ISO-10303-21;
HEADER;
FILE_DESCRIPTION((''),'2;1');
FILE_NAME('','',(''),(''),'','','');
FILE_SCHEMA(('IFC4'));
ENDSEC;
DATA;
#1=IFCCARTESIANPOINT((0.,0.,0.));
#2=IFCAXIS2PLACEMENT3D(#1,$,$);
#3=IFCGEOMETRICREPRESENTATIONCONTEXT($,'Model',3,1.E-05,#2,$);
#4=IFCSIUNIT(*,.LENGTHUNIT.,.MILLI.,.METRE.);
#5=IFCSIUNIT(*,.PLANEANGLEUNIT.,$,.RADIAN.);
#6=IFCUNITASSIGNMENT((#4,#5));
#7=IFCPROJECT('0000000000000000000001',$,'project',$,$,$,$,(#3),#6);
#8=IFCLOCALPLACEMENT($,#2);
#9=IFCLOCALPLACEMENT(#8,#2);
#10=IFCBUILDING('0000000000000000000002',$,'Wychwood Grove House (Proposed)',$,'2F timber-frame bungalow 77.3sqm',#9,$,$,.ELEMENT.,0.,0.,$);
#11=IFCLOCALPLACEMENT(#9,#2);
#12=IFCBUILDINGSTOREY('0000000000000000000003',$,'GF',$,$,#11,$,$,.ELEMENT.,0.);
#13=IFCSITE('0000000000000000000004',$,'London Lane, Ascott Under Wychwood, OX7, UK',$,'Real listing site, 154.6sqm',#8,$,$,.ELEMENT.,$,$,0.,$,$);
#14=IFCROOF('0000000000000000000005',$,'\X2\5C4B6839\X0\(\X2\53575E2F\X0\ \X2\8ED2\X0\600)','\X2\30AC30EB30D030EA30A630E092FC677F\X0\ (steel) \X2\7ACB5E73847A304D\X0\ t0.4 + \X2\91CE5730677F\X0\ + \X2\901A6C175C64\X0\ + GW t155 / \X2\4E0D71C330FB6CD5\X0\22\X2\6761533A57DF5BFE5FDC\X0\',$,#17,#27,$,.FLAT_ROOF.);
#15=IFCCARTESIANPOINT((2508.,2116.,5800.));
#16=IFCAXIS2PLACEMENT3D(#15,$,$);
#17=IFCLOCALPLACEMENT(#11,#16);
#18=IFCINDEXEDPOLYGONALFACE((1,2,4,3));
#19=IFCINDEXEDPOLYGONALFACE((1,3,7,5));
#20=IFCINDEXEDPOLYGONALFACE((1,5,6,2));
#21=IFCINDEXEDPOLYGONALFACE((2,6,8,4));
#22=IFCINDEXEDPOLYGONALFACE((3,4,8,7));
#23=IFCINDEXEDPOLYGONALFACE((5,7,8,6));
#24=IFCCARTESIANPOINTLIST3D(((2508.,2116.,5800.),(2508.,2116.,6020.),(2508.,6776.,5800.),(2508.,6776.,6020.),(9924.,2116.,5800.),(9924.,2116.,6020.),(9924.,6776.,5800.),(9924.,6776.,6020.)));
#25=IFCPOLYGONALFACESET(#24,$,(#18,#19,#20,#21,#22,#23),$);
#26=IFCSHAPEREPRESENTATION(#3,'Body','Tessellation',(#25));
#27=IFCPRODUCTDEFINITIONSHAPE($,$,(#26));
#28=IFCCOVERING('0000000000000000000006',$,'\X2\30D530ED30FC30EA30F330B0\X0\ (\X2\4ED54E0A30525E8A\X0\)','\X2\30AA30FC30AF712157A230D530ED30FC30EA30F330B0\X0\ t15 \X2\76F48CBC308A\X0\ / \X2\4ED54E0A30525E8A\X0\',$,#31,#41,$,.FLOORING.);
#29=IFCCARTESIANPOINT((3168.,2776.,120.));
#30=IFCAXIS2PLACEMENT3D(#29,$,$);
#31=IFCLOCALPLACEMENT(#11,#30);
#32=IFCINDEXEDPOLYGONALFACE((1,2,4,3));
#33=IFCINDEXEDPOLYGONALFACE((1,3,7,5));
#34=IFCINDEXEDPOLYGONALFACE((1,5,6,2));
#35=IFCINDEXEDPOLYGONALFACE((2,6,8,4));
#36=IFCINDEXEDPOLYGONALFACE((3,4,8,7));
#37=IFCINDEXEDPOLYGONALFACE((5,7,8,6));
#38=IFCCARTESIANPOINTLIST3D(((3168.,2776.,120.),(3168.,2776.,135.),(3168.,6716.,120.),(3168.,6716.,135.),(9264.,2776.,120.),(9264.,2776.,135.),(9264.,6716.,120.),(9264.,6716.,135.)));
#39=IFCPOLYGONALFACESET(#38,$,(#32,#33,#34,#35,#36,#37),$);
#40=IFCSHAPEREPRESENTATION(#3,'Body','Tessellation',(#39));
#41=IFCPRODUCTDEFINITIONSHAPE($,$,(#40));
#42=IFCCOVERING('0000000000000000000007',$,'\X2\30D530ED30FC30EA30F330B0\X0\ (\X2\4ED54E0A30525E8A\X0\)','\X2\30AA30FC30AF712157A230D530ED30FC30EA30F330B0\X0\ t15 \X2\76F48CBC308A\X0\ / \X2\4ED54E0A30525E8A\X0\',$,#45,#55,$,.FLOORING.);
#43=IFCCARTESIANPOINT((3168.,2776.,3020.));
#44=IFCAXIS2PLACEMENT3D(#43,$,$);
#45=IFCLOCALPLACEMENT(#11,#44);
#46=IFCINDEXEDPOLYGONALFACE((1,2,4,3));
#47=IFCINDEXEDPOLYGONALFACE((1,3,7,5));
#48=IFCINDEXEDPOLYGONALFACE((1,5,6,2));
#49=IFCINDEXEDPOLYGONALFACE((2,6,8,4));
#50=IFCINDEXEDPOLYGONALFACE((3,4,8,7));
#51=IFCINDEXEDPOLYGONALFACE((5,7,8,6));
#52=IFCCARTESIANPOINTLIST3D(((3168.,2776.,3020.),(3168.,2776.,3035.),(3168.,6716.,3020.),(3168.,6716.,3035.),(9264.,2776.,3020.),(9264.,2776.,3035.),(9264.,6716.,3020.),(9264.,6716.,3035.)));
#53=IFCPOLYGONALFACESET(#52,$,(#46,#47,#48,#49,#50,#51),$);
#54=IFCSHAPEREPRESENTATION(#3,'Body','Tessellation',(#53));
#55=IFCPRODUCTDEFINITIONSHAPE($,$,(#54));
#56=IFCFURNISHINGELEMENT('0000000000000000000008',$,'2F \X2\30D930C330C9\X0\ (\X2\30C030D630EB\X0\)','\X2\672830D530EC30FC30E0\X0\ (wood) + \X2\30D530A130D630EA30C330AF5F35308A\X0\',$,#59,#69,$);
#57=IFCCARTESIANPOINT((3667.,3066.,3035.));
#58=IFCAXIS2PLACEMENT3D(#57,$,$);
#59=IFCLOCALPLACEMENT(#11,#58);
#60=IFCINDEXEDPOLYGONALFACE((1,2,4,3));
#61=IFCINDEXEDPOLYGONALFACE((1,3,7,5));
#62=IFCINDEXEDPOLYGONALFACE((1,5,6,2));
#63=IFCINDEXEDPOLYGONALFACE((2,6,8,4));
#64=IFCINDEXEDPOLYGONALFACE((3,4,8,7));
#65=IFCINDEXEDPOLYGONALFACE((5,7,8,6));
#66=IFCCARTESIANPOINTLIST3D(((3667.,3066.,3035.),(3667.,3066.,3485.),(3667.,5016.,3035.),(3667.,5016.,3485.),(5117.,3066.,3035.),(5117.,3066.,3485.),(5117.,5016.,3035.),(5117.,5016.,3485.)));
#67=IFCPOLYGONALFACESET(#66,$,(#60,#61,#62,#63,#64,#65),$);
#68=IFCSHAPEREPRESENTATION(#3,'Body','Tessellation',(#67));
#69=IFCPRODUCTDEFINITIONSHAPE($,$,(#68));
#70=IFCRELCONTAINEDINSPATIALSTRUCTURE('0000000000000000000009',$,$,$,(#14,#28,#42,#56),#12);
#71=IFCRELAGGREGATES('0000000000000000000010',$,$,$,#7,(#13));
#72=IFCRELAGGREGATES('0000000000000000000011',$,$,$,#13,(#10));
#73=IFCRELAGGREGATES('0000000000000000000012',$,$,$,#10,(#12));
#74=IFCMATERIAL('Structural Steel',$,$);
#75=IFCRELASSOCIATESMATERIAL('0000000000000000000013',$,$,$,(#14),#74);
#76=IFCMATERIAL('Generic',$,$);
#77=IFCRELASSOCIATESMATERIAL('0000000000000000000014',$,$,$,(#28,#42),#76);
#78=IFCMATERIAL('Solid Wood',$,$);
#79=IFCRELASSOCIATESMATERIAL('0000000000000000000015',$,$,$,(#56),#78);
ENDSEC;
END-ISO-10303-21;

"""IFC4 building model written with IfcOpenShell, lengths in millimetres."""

from ifc_helpers import new_model, si_unit, frame, frame_2d, origin, place, context, project, spatial, rectangle, extrude, material, element, save


model = new_model("IFC4")

# Units and contexts
model_context = context("Model", 3, precision=1e-05, world=origin())
ifc_project = project(units=[si_unit("LENGTHUNIT", "METRE", prefix="MILLI"), si_unit("PLANEANGLEUNIT", "RADIAN")], contexts=[model_context])

# Site, building, storey
site_placement = place(None, origin())
site = spatial("IfcSite", under=ifc_project, at=site_placement, Name="London Lane, Ascott Under Wychwood, OX7, UK", ObjectType="Real listing site, 154.6sqm", CompositionType="ELEMENT", RefElevation=0.0)
building_placement = place(site_placement, origin())
building = spatial("IfcBuilding", under=site, at=building_placement, Name="Wychwood Grove House (Proposed)", ObjectType="2F timber-frame bungalow 77.3sqm", CompositionType="ELEMENT", ElevationOfRefHeight=0.0, ElevationOfTerrain=0.0)
storey_placement = place(building_placement, origin())
storey = spatial("IfcBuildingStorey", under=building, at=storey_placement, Name="GF", CompositionType="ELEMENT", Elevation=0.0)

# Shared definitions
ifc_material_1 = material(Name="Solid Wood")

# Roof
ifc_material_2 = material(Name="Structural Steel")
for number, where, name in (
    (1, (2508.0, 2116.0, 5800.0), "屋根(南帯 軒600)"),
):
    element("IfcRoof", number, at=place(storey_placement, frame(where)), inside=storey, material=ifc_material_2, Name=name, Description="ガルバリウム鋼板 (steel) 立平葺き t0.4 + 野地板 + 通気層 + GW t155 / 不燃・法22条区域対応", PredefinedType="FLAT_ROOF", context=model_context, shape_type="SweptSolid", body=[
        extrude(rectangle(XDim=7416.0, YDim=4660.0, at=frame_2d((3708.0, 2330.0))), frame((2508.0, 2116.0, 5800.0)), (0.0, 0.0, 1.0), 220.0),
    ])

# Coverings
ifc_material_3 = material(Name="Generic")
covering_1_placement = place(storey_placement, frame((3168.0, 2776.0, 120.0)))
element("IfcCovering", 2, at=covering_1_placement, inside=storey, material=ifc_material_3, Name="フローリング (仕上げ床)", Description="オーク無垢フローリング t15 直貼り / 仕上げ床", PredefinedType="FLOORING", context=model_context, shape_type="SweptSolid", body=[
    extrude(rectangle(XDim=6096.0, YDim=3940.0, at=frame_2d((3048.0, 1970.0))), frame((3168.0, 2776.0, 120.0)), (0.0, 0.0, 1.0), 15.0),
])
covering_2_placement = place(storey_placement, frame((3168.0, 2776.0, 3020.0)))
element("IfcCovering", 3, at=covering_2_placement, inside=storey, material=ifc_material_3, Name="フローリング (仕上げ床)", Description="オーク無垢フローリング t15 直貼り / 仕上げ床", PredefinedType="FLOORING", context=model_context, shape_type="SweptSolid", body=[
    extrude(rectangle(XDim=6096.0, YDim=3940.0, at=frame_2d((3048.0, 1970.0))), frame((3168.0, 2776.0, 3020.0)), (0.0, 0.0, 1.0), 15.0),
])

# Furnishing element
furnishing_placement = place(storey_placement, frame((3667.0, 3066.0, 3035.0)))
element("IfcFurnishingElement", 4, at=furnishing_placement, inside=storey, material=ifc_material_1, Name="2F ベッド (ダブル)", Description="木フレーム (wood) + ファブリック張り", context=model_context, shape_type="SweptSolid", body=[
    extrude(rectangle(XDim=1450.0, YDim=1950.0, at=frame_2d((725.0, 975.0))), frame((3667.0, 3066.0, 3035.0)), (0.0, 0.0, 1.0), 450.0),
])

save(model, "model.ifc")
